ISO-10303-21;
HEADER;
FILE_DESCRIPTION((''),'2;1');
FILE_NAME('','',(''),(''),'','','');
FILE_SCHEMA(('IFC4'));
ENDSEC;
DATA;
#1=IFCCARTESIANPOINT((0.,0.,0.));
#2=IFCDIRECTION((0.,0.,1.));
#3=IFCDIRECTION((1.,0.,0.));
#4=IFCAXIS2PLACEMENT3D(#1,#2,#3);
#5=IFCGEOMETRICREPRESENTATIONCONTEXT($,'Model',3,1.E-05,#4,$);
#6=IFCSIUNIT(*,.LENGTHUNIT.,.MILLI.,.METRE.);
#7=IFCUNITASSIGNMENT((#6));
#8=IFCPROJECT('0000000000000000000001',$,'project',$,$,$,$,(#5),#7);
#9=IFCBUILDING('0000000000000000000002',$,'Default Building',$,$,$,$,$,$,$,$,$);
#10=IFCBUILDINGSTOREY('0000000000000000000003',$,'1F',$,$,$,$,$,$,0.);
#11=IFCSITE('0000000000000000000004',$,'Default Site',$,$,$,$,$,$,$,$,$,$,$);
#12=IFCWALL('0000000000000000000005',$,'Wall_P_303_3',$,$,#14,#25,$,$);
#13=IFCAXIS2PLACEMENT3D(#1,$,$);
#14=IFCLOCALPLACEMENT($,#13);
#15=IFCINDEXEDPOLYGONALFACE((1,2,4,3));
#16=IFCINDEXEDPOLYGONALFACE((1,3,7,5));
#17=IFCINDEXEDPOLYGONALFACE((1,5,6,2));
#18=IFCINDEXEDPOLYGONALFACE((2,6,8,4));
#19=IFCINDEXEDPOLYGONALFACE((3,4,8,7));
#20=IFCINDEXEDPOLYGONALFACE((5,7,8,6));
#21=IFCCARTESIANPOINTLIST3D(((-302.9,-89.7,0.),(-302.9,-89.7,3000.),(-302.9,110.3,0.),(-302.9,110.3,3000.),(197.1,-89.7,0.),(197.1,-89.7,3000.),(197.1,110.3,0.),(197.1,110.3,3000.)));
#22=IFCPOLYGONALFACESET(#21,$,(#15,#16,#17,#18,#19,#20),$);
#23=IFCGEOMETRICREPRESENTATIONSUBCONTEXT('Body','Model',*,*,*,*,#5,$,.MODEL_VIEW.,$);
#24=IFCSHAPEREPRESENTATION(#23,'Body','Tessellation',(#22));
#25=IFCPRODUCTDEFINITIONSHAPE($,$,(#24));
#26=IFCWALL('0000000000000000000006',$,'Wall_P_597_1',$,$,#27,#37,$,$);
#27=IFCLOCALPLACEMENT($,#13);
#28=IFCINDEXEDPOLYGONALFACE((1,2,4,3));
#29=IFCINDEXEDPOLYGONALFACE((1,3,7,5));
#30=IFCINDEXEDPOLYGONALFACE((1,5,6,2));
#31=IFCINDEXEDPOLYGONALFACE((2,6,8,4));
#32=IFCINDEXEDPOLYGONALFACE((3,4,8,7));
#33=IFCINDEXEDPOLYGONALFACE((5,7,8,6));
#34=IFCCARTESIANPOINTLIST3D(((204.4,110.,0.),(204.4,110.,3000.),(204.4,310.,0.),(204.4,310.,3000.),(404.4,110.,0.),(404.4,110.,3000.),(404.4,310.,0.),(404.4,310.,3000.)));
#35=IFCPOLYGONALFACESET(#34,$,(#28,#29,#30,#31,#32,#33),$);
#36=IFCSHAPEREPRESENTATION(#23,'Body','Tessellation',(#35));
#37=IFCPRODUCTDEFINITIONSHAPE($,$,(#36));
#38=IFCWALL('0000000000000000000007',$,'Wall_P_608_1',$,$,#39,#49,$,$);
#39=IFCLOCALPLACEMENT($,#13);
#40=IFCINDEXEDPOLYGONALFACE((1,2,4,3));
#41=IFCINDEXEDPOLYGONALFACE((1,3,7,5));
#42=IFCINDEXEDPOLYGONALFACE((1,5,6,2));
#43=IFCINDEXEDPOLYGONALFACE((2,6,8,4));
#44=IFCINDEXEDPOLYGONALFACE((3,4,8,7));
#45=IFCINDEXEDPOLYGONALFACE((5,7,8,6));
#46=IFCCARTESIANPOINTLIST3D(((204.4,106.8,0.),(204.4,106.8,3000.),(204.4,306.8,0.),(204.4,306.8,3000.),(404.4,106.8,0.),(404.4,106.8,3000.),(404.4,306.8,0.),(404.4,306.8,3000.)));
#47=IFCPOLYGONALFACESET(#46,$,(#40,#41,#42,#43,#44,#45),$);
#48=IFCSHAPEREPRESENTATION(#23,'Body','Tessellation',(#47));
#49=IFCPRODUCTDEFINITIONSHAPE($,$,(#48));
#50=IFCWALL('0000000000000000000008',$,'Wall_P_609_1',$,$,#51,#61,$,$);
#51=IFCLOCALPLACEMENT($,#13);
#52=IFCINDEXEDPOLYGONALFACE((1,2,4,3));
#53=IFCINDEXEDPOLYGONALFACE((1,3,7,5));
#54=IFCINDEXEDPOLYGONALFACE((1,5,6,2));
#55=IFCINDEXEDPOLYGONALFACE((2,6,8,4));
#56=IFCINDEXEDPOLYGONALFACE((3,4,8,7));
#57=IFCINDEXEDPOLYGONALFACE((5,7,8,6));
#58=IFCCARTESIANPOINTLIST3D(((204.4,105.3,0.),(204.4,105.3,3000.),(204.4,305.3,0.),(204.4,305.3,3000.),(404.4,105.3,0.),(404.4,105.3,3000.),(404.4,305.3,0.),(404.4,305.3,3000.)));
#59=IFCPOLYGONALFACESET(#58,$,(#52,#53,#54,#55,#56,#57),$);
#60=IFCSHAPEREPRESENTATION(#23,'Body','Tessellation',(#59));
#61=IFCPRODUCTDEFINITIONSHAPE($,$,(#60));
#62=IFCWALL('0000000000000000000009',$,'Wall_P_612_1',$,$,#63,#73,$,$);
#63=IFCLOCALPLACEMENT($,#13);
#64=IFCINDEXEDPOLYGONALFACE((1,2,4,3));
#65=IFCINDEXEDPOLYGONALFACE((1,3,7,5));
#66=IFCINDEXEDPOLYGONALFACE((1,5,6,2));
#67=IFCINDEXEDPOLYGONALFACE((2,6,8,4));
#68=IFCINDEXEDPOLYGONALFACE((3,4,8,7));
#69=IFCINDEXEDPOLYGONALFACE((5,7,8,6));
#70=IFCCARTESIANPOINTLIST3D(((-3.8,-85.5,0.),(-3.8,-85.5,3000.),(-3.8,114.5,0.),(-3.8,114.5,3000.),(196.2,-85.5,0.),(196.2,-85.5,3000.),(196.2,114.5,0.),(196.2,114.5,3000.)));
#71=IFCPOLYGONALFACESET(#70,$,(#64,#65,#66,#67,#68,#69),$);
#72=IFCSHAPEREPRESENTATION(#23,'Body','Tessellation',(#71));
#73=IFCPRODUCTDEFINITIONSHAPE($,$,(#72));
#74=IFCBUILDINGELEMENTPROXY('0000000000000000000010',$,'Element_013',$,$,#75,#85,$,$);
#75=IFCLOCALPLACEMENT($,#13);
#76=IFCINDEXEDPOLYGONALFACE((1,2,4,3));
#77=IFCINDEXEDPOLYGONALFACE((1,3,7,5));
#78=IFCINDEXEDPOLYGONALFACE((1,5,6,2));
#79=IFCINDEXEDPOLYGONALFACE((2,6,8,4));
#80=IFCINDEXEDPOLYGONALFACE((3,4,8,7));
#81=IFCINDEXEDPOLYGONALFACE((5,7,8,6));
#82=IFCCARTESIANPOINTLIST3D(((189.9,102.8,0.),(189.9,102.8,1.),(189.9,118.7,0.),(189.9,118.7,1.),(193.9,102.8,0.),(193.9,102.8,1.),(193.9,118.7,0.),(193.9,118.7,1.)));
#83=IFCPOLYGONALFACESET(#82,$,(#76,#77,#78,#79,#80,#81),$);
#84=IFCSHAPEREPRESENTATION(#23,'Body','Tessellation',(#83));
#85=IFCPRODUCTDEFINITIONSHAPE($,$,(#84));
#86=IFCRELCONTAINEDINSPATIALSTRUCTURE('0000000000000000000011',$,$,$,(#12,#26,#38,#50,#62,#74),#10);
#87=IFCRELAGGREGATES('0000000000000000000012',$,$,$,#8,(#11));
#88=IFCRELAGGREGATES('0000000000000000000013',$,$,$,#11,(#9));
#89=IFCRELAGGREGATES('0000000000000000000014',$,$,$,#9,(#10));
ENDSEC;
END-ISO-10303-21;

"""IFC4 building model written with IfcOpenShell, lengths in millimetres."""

from ifc_helpers import new_model, si_unit, frame, origin, origin_with_axes, place, context, subcontext, project, spatial, indexed_curve, rectangle, outline, extrude, element, save


model = new_model("IFC4")

# Units and contexts
model_context = context("Model", 3, precision=1e-05, world=origin_with_axes())
body_context = subcontext(model_context, "Body", "Model", "MODEL_VIEW")
ifc_project = project(units=[si_unit("LENGTHUNIT", "METRE", prefix="MILLI")], contexts=[model_context])

# Site, building, storey
site = spatial("IfcSite", under=ifc_project, Name="Default Site")
building = spatial("IfcBuilding", under=site, Name="Default Building")
storey = spatial("IfcBuildingStorey", under=building, Name="1F", Elevation=0.0)

# Walls
wall_1_placement = place(None, frame((197.1, 110.3, 0.0), z_axis=(0.0, 0.0, 1.0), x_axis=(-1.0, 0.0, 0.0)))
element("IfcWall", 1, at=wall_1_placement, inside=storey, Name="Wall_P_303_3", context=body_context, shape_type="SweptSolid", body=[
    extrude(outline(indexed_curve([(0.0, 0.0), (0.0, 200.0), (500.0, 200.0), (500.0, 0.0), (0.0, 0.0)], self_intersect=False)), origin_with_axes(), (0.0, 0.0, 1.0), 3000.0),
])
for number, where, z_axis, x_axis, name in (
    (2, (204.4, 110.0, 0.0), (0.0, 0.0, 1.0), (1.0, 0.0, 0.0), "Wall_P_597_1"),
    (3, (204.4, 106.8, 0.0), (0.0, 0.0, 1.0), (1.0, 0.0, 0.0), "Wall_P_608_1"),
    (4, (204.4, 105.3, 0.0), (0.0, 0.0, 1.0), (1.0, 0.0, 0.0), "Wall_P_609_1"),
    (5, (196.2, 114.5, 0.0), (0.0, 0.0, 1.0), (-1.0, 0.0, 0.0), "Wall_P_612_1"),
):
    element("IfcWall", number, at=place(None, frame(where, z_axis=z_axis, x_axis=x_axis)), inside=storey, Name=name, context=body_context, shape_type="SweptSolid", body=[
        extrude(outline(indexed_curve([(0.0, 0.0), (0.0, 200.0), (200.0, 200.0), (200.0, 0.0), (0.0, 0.0)], self_intersect=False)), origin_with_axes(), (0.0, 0.0, 1.0), 3000.0),
    ])

# Building element proxy
proxy_1_placement = place(None, frame((191.9, 110.8, 0.0), z_axis=(0.0, 0.0, 1.0), x_axis=(1.0, 0.0, 0.0)))
element("IfcBuildingElementProxy", 6, at=proxy_1_placement, inside=storey, Name="Element_013", context=body_context, shape_type="SweptSolid", body=[
    extrude(rectangle(XDim=4.0, YDim=15.9), origin(), (0.0, 0.0, 1.0), 1.0),
])

save(model, "model.ifc")
